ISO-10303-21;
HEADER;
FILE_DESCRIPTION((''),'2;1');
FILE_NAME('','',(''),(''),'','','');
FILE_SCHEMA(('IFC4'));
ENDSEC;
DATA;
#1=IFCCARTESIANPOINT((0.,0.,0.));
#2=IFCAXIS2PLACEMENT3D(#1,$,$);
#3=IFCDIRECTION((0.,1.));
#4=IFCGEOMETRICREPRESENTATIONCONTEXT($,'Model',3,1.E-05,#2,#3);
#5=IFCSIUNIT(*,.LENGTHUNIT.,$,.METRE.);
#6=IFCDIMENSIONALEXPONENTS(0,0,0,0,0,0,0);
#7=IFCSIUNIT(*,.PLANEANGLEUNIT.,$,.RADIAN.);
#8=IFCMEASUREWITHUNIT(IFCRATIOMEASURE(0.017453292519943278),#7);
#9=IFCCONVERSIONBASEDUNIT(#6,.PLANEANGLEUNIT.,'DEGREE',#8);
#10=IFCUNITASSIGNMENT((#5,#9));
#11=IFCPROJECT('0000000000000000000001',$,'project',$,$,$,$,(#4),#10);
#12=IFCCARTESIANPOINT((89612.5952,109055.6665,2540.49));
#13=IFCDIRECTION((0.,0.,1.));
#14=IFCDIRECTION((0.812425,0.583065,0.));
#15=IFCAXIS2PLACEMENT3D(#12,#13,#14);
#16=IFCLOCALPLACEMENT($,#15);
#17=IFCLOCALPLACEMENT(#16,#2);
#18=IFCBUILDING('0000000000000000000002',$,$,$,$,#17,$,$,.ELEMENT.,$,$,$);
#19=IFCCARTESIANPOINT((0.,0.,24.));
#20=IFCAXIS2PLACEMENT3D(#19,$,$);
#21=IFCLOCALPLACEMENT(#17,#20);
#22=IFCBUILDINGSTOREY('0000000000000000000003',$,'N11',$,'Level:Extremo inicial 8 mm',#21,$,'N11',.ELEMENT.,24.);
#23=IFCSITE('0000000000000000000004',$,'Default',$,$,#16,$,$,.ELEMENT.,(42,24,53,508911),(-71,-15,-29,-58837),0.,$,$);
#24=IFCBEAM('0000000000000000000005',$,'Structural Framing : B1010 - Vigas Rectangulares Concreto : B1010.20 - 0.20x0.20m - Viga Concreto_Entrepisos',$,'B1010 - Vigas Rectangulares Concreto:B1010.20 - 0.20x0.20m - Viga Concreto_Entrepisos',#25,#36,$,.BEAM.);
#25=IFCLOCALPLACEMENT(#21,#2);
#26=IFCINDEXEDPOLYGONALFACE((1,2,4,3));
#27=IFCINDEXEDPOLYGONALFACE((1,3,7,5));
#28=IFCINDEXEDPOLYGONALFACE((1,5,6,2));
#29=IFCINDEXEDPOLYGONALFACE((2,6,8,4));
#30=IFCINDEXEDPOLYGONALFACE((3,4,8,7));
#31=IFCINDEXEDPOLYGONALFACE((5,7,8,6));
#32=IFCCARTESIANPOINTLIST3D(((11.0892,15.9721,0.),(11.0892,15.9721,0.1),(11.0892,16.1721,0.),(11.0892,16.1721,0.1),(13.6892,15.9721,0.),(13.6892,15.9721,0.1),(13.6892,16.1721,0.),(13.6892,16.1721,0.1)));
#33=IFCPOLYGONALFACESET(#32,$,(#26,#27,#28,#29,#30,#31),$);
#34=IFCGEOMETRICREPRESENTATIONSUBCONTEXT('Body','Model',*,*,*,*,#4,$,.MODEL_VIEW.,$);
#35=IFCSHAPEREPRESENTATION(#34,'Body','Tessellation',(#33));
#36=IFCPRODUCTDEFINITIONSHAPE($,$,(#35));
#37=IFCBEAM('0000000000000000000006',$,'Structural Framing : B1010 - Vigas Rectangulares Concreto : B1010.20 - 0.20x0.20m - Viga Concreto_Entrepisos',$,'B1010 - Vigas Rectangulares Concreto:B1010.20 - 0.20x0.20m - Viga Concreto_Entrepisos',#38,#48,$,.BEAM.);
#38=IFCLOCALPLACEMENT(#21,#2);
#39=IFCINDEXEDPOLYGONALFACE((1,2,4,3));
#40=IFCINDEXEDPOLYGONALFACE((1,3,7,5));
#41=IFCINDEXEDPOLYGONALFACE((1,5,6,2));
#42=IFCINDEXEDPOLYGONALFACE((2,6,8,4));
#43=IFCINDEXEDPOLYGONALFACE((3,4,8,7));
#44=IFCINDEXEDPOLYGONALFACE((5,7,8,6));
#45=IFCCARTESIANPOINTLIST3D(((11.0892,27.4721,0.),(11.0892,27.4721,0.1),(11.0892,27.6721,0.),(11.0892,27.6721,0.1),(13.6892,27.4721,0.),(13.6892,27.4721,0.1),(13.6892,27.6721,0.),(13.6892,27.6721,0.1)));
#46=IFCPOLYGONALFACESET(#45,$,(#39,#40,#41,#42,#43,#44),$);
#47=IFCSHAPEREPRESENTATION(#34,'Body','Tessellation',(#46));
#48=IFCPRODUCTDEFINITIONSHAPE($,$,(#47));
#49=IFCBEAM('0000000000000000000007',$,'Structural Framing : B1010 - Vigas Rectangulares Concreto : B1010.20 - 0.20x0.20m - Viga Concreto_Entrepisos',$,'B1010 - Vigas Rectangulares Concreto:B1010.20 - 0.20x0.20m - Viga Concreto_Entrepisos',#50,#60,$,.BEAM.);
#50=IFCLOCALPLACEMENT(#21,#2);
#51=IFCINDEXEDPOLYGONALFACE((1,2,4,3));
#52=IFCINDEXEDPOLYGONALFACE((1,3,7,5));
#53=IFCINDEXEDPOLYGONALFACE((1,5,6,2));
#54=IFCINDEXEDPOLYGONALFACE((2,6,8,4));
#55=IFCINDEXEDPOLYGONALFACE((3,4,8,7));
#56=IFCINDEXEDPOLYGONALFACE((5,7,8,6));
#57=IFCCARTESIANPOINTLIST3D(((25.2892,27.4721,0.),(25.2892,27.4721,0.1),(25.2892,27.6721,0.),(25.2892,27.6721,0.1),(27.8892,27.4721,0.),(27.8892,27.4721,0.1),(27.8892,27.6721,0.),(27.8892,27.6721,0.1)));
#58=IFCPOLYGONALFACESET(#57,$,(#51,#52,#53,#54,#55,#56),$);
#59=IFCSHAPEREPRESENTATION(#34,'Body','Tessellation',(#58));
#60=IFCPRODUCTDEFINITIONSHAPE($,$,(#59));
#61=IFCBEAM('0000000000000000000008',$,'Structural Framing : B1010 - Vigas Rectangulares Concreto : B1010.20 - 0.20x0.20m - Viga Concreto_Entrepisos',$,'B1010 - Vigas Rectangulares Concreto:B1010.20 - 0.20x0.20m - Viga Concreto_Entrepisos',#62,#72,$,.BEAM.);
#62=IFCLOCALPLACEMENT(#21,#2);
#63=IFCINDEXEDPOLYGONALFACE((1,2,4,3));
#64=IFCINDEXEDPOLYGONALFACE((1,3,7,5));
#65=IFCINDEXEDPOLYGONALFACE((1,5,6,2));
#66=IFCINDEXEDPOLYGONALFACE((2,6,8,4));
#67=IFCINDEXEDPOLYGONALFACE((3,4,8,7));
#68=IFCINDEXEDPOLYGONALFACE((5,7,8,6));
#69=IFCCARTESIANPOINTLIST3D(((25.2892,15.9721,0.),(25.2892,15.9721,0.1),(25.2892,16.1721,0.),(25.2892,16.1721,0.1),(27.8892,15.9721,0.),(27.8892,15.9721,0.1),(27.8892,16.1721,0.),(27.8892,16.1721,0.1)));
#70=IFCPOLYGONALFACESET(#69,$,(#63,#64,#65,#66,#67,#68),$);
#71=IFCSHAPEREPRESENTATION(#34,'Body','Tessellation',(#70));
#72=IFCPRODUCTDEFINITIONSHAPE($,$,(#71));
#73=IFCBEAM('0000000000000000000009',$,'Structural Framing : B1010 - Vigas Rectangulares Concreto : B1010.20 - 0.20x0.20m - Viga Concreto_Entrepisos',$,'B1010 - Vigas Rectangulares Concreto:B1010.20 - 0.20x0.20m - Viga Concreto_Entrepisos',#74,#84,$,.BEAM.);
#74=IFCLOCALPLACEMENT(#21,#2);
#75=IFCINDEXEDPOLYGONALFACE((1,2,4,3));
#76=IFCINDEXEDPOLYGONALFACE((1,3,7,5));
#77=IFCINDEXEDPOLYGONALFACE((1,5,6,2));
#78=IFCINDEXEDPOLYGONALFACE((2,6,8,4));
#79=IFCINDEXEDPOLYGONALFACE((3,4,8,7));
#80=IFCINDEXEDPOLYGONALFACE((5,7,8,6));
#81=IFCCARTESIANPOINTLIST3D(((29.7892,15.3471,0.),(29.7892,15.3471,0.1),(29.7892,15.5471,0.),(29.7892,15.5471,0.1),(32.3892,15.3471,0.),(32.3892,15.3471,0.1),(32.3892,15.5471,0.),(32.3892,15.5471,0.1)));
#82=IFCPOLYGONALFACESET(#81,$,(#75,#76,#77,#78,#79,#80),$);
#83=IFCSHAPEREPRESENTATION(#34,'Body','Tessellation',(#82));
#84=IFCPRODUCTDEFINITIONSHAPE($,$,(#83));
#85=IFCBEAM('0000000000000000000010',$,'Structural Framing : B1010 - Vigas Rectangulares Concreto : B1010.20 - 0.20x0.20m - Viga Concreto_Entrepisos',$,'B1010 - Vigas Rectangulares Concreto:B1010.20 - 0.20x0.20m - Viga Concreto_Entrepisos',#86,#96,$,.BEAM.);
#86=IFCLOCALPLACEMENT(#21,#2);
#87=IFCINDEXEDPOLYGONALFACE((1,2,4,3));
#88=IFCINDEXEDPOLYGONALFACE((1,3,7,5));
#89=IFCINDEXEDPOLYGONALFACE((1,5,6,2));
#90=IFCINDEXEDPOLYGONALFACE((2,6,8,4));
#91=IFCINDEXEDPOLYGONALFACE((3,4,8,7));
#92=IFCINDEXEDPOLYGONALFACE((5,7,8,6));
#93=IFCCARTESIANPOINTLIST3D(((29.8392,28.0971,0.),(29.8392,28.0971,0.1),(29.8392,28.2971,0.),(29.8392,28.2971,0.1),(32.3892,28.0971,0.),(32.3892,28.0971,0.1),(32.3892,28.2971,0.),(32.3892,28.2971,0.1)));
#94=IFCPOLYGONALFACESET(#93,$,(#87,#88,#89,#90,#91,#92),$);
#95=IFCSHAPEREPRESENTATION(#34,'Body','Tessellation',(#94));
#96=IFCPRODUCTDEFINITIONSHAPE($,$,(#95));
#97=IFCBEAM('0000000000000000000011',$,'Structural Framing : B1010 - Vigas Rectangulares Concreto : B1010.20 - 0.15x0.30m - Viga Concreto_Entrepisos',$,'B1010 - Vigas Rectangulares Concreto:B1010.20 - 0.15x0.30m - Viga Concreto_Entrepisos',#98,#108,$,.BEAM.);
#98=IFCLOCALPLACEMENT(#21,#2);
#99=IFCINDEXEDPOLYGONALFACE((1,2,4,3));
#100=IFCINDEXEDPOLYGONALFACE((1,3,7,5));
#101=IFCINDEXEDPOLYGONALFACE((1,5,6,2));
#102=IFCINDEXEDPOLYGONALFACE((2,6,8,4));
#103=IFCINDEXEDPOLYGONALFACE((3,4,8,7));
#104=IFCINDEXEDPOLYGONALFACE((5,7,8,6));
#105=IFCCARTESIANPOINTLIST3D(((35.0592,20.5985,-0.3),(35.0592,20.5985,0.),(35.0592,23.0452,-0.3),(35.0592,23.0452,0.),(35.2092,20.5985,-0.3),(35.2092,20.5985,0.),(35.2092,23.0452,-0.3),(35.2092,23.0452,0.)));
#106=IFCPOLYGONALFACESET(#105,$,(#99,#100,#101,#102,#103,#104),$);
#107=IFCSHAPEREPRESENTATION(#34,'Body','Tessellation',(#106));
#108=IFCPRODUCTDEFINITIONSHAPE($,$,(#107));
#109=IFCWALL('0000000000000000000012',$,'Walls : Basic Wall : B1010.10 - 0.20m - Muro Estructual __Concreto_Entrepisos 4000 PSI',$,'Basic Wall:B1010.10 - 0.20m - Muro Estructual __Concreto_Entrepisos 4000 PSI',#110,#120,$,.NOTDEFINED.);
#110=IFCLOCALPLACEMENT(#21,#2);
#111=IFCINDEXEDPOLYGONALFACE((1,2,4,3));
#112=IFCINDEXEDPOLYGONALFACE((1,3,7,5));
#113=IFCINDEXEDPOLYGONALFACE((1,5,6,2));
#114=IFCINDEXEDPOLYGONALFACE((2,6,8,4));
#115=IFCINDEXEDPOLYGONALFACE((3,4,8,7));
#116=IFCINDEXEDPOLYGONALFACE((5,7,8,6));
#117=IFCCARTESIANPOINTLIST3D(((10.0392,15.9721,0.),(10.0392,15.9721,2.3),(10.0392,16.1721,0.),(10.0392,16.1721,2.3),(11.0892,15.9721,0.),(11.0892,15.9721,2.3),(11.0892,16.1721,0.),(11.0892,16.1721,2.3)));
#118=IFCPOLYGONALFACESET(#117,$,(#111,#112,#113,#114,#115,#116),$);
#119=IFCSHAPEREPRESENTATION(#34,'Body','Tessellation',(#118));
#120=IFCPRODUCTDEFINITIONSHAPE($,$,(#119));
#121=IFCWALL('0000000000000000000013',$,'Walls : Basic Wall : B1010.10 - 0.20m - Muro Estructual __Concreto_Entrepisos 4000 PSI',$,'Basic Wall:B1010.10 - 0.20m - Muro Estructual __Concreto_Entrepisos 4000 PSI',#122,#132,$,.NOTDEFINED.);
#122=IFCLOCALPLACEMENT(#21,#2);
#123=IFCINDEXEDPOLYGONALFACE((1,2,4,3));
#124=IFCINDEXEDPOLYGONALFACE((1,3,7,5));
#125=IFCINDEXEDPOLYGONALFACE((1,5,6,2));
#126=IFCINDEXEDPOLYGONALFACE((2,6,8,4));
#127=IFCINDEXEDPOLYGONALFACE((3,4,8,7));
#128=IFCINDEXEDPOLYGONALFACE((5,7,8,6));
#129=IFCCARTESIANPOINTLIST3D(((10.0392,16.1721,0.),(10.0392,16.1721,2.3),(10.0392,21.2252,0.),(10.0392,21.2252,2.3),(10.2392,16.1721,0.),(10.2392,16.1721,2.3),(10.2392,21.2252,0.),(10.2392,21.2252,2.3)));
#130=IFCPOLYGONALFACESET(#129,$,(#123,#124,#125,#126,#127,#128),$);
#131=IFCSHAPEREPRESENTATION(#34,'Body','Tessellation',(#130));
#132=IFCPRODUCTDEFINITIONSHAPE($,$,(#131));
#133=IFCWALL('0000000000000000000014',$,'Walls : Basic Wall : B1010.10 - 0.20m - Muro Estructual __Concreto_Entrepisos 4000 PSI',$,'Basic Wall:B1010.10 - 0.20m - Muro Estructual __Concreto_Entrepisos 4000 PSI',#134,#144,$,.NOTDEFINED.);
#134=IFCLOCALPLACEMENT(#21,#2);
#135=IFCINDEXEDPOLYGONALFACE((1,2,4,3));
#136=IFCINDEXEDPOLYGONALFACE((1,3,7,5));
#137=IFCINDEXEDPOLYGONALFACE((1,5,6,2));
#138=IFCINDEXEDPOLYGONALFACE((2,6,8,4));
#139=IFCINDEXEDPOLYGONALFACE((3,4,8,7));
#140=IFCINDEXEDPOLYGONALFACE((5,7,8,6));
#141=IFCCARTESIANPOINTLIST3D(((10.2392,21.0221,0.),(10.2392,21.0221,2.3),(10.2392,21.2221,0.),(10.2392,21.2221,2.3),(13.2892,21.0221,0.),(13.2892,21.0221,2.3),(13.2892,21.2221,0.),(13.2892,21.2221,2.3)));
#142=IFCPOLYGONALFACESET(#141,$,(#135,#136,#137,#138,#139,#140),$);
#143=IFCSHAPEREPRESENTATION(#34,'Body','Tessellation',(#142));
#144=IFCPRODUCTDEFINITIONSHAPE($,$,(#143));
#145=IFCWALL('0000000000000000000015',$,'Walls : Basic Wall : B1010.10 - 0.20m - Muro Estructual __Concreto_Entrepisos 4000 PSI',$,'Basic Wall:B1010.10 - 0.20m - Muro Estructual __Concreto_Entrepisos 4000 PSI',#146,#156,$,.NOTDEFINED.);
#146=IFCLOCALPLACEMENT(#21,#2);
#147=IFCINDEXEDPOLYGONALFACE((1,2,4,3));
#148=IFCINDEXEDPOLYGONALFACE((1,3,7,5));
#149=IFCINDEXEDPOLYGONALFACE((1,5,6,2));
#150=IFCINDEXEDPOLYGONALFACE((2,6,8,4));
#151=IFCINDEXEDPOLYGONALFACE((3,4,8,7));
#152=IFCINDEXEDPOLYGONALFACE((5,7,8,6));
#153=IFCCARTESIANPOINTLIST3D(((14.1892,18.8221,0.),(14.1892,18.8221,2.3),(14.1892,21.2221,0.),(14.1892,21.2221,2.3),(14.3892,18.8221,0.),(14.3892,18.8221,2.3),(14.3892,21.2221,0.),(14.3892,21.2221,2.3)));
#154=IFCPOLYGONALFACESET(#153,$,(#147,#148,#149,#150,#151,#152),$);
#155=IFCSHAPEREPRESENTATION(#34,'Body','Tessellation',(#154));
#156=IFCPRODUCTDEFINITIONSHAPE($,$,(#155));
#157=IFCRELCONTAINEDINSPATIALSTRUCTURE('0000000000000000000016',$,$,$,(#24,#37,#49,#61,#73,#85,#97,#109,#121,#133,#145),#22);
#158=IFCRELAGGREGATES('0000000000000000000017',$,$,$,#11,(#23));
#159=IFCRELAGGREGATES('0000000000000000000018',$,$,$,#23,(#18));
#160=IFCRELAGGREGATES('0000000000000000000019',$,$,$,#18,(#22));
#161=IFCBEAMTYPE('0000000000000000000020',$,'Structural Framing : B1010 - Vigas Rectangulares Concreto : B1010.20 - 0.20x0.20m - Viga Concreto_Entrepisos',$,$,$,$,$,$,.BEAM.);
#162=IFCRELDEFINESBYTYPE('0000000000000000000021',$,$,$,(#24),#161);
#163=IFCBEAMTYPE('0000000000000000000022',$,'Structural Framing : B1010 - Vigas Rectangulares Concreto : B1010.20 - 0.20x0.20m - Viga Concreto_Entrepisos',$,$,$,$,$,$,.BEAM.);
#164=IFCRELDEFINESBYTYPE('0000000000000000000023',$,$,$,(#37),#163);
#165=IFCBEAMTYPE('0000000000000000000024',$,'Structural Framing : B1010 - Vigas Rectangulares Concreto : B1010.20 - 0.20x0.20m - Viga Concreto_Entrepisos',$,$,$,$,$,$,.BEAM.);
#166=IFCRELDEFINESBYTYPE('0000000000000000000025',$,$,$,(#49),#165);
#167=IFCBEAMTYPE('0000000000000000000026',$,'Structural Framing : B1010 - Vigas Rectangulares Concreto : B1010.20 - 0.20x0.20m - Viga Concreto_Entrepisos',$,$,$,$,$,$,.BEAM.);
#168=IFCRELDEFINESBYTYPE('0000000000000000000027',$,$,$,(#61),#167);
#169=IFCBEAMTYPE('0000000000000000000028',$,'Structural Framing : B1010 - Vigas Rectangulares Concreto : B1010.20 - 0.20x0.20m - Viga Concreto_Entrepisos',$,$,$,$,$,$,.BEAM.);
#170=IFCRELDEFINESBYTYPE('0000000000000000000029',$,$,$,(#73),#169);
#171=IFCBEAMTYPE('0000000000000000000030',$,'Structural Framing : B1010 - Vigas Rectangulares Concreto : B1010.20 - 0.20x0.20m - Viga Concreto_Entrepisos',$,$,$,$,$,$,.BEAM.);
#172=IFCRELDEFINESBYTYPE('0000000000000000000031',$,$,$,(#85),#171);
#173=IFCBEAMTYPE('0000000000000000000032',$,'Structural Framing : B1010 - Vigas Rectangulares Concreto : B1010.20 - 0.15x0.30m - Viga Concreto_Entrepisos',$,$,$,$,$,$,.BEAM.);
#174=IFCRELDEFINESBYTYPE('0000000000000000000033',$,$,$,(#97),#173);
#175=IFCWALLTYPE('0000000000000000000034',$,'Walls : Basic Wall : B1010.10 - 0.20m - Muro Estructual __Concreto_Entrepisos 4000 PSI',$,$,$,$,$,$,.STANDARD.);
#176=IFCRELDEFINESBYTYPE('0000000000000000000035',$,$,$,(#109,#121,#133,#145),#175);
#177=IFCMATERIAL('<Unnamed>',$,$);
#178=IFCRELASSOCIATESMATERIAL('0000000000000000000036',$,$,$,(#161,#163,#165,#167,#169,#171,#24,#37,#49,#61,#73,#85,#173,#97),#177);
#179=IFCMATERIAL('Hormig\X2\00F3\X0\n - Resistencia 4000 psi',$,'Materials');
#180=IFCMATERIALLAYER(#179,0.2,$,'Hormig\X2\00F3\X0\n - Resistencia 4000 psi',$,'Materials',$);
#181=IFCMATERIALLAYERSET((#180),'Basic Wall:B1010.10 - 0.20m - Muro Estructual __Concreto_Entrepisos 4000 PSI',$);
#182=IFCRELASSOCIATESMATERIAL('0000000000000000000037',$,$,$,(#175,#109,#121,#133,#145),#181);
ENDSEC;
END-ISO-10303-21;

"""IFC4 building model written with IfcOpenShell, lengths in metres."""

from ifc_helpers import new_model, entity, si_unit, converted_unit, direction, frame, frame_2d, origin, place, context, subcontext, project, spatial, polyline, segment, composite_curve, rectangle, outline, extrude, source, transform, mapped, material, layer, layer_set, layer_usage, material_profile, profile_set, profile_usage, type_object, type_shapes, element, save


model = new_model("IFC4")

# Units and contexts
model_context = context("Model", 3, precision=1e-05, world=origin(), true_north=direction((0.0, 1.0)))
body_context = subcontext(model_context, "Body", "Model", "MODEL_VIEW")
ifc_project = project(units=[si_unit("LENGTHUNIT", "METRE"), converted_unit("PLANEANGLEUNIT", "DEGREE", entity("IfcRatioMeasure", 0.017453292519943278), si_unit("PLANEANGLEUNIT", "RADIAN"), dimensions=[0, 0, 0, 0, 0, 0, 0])], contexts=[model_context])

# Site, building, storey
site_placement = place(None, frame((89612.5952, 109055.6665, 2540.49), z_axis=(0.0, 0.0, 1.0), x_axis=(0.812425, 0.583065, 0.0)))
site = spatial("IfcSite", under=ifc_project, at=site_placement, Name="Default", CompositionType="ELEMENT", RefLatitude=(42, 24, 53, 508911), RefLongitude=(-71, -15, -29, -58837), RefElevation=0.0)
building_placement = place(site_placement, origin())
building = spatial("IfcBuilding", under=site, at=building_placement, CompositionType="ELEMENT")
storey_placement = place(building_placement, frame((0.0, 0.0, 24.0)))
storey = spatial("IfcBuildingStorey", under=building, at=storey_placement, Name="N11", ObjectType="Level:Extremo inicial 8 mm", LongName="N11", CompositionType="ELEMENT", Elevation=24.0)

# Beams
ifc_material_1 = material(Name="<Unnamed>")
ifc_material_profile_1 = material_profile(ifc_material_1, outline(composite_curve([segment(polyline([(-0.1, 0.0, 0.0), (-0.1, 0.1, 0.0)]), True, "CONTINUOUS"), segment(polyline([(-0.1, 0.1, 0.0), (0.1, 0.1, 0.0)]), True, "CONTINUOUS"), segment(polyline([(0.1, 0.1, 0.0), (0.1, 0.0, 0.0)]), True, "CONTINUOUS"), segment(polyline([(0.1, 0.0, 0.0), (-0.1, 0.0, 0.0)]), True, "CONTINUOUS")], self_intersect=False), kind="CURVE"), Name="B1010.20 - 0.20x0.20m - Viga Concreto_Entrepisos")
ifc_material_profile_2 = material_profile(ifc_material_1, outline(composite_curve([segment(polyline([(-1.3, -0.1, 0.1), (-1.3, 0.1, 0.1)]), True, "CONTINUOUS"), segment(polyline([(-1.3, 0.1, 0.1), (-1.3, 0.1, -0.1)]), True, "CONTINUOUS"), segment(polyline([(-1.3, 0.1, -0.1), (-1.3, -0.1, -0.1)]), True, "CONTINUOUS"), segment(polyline([(-1.3, -0.1, -0.1), (-1.3, -0.1, 0.1)]), True, "CONTINUOUS")], self_intersect=False), kind="CURVE"), Name="B1010.20 - 0.20x0.20m - Viga Concreto_Entrepisos")
ifc_profile_set_1 = profile_set([ifc_material_profile_1, ifc_material_profile_2], Name="B1010.20 - 0.20x0.20m - Viga Concreto_Entrepisos")
ifc_profile_usage_1 = profile_usage(ifc_profile_set_1, cardinal=8)
beam_type_1 = type_object("IfcBeamType", Name="Structural Framing : B1010 - Vigas Rectangulares Concreto : B1010.20 - 0.20x0.20m - Viga Concreto_Entrepisos", PredefinedType="BEAM", material=ifc_profile_set_1)
shared_shape_1 = source(origin(), body_context, "Body", "SweptSolid", [
    extrude(rectangle(XDim=0.1, YDim=0.2, at=frame_2d((0.0, 0.0), x_axis=(1.0, 0.0))), frame((13.6892, 16.0721, 24.05), z_axis=(-1.0, 0.0, 0.0), x_axis=(0.0, 0.0, -1.0)), (0.0, 0.0, 1.0), 2.6),
])
type_shapes(beam_type_1, [shared_shape_1])
beam_1_placement = place(storey_placement, frame((0.0, 0.0, -24.0)))
element("IfcBeam", 1, at=beam_1_placement, inside=storey, type_object=beam_type_1, material=ifc_profile_usage_1, Name="Structural Framing : B1010 - Vigas Rectangulares Concreto : B1010.20 - 0.20x0.20m - Viga Concreto_Entrepisos", ObjectType="B1010 - Vigas Rectangulares Concreto:B1010.20 - 0.20x0.20m - Viga Concreto_Entrepisos", PredefinedType="BEAM", context=body_context, shape_type="MappedRepresentation", body=[
    mapped(shared_shape_1, transform((0.0, 0.0, 0.0), scale=1.0)),
])
ifc_profile_usage_2 = profile_usage(ifc_profile_set_1, cardinal=8)
beam_type_2 = type_object("IfcBeamType", Name="Structural Framing : B1010 - Vigas Rectangulares Concreto : B1010.20 - 0.20x0.20m - Viga Concreto_Entrepisos", PredefinedType="BEAM", material=ifc_profile_set_1)
shared_shape_2 = source(origin(), body_context, "Body", "SweptSolid", [
    extrude(rectangle(XDim=0.1, YDim=0.2, at=frame_2d((0.0, 0.0), x_axis=(1.0, 0.0))), frame((13.6892, 27.5721, 24.05), z_axis=(-1.0, 0.0, 0.0), x_axis=(0.0, 0.0, -1.0)), (0.0, 0.0, 1.0), 2.6),
])
type_shapes(beam_type_2, [shared_shape_2])
beam_2_placement = place(storey_placement, frame((0.0, 0.0, -24.0)))
element("IfcBeam", 2, at=beam_2_placement, inside=storey, type_object=beam_type_2, material=ifc_profile_usage_2, Name="Structural Framing : B1010 - Vigas Rectangulares Concreto : B1010.20 - 0.20x0.20m - Viga Concreto_Entrepisos", ObjectType="B1010 - Vigas Rectangulares Concreto:B1010.20 - 0.20x0.20m - Viga Concreto_Entrepisos", PredefinedType="BEAM", context=body_context, shape_type="MappedRepresentation", body=[
    mapped(shared_shape_2, transform((0.0, 0.0, 0.0), scale=1.0)),
])
ifc_profile_usage_3 = profile_usage(ifc_profile_set_1, cardinal=8)
beam_type_3 = type_object("IfcBeamType", Name="Structural Framing : B1010 - Vigas Rectangulares Concreto : B1010.20 - 0.20x0.20m - Viga Concreto_Entrepisos", PredefinedType="BEAM", material=ifc_profile_set_1)
shared_shape_3 = source(origin(), body_context, "Body", "SweptSolid", [
    extrude(rectangle(XDim=0.1, YDim=0.2, at=frame_2d((0.0, 0.0), x_axis=(1.0, 0.0))), frame((25.2892, 27.5721, 24.05), z_axis=(1.0, 0.0, 0.0), x_axis=(0.0, 0.0, -1.0)), (0.0, 0.0, 1.0), 2.6),
])
type_shapes(beam_type_3, [shared_shape_3])
beam_3_placement = place(storey_placement, frame((0.0, 0.0, -24.0)))
element("IfcBeam", 3, at=beam_3_placement, inside=storey, type_object=beam_type_3, material=ifc_profile_usage_3, Name="Structural Framing : B1010 - Vigas Rectangulares Concreto : B1010.20 - 0.20x0.20m - Viga Concreto_Entrepisos", ObjectType="B1010 - Vigas Rectangulares Concreto:B1010.20 - 0.20x0.20m - Viga Concreto_Entrepisos", PredefinedType="BEAM", context=body_context, shape_type="MappedRepresentation", body=[
    mapped(shared_shape_3, transform((0.0, 0.0, 0.0), scale=1.0)),
])
ifc_profile_usage_4 = profile_usage(ifc_profile_set_1, cardinal=8)
beam_type_4 = type_object("IfcBeamType", Name="Structural Framing : B1010 - Vigas Rectangulares Concreto : B1010.20 - 0.20x0.20m - Viga Concreto_Entrepisos", PredefinedType="BEAM", material=ifc_profile_set_1)
shared_shape_4 = source(origin(), body_context, "Body", "SweptSolid", [
    extrude(rectangle(XDim=0.1, YDim=0.2, at=frame_2d((0.0, 0.0), x_axis=(1.0, 0.0))), frame((25.2892, 16.0721, 24.05), z_axis=(1.0, 0.0, 0.0), x_axis=(0.0, 0.0, -1.0)), (0.0, 0.0, 1.0), 2.6),
])
type_shapes(beam_type_4, [shared_shape_4])
beam_4_placement = place(storey_placement, frame((0.0, 0.0, -24.0)))
element("IfcBeam", 4, at=beam_4_placement, inside=storey, type_object=beam_type_4, material=ifc_profile_usage_4, Name="Structural Framing : B1010 - Vigas Rectangulares Concreto : B1010.20 - 0.20x0.20m - Viga Concreto_Entrepisos", ObjectType="B1010 - Vigas Rectangulares Concreto:B1010.20 - 0.20x0.20m - Viga Concreto_Entrepisos", PredefinedType="BEAM", context=body_context, shape_type="MappedRepresentation", body=[
    mapped(shared_shape_4, transform((0.0, 0.0, 0.0), scale=1.0)),
])
ifc_profile_usage_5 = profile_usage(ifc_profile_set_1, cardinal=8)
beam_type_5 = type_object("IfcBeamType", Name="Structural Framing : B1010 - Vigas Rectangulares Concreto : B1010.20 - 0.20x0.20m - Viga Concreto_Entrepisos", PredefinedType="BEAM", material=ifc_profile_set_1)
shared_shape_5 = source(origin(), body_context, "Body", "SweptSolid", [
    extrude(rectangle(XDim=0.1, YDim=0.2, at=frame_2d((0.0, 0.0), x_axis=(1.0, 0.0))), frame((32.3892, 15.4471, 24.05), z_axis=(-1.0, 0.0, 0.0), x_axis=(0.0, 0.0, -1.0)), (0.0, 0.0, 1.0), 2.6),
])
type_shapes(beam_type_5, [shared_shape_5])
beam_5_placement = place(storey_placement, frame((0.0, 0.0, -24.0)))
element("IfcBeam", 5, at=beam_5_placement, inside=storey, type_object=beam_type_5, material=ifc_profile_usage_5, Name="Structural Framing : B1010 - Vigas Rectangulares Concreto : B1010.20 - 0.20x0.20m - Viga Concreto_Entrepisos", ObjectType="B1010 - Vigas Rectangulares Concreto:B1010.20 - 0.20x0.20m - Viga Concreto_Entrepisos", PredefinedType="BEAM", context=body_context, shape_type="MappedRepresentation", body=[
    mapped(shared_shape_5, transform((0.0, 0.0, 0.0), scale=1.0)),
])
ifc_profile_usage_6 = profile_usage(ifc_profile_set_1, cardinal=8)
beam_type_6 = type_object("IfcBeamType", Name="Structural Framing : B1010 - Vigas Rectangulares Concreto : B1010.20 - 0.20x0.20m - Viga Concreto_Entrepisos", PredefinedType="BEAM", material=ifc_profile_set_1)
shared_shape_6 = source(origin(), body_context, "Body", "SweptSolid", [
    extrude(rectangle(XDim=0.1, YDim=0.2, at=frame_2d((0.0, 0.0), x_axis=(1.0, 0.0))), frame((29.8392, 28.1971, 24.05), z_axis=(1.0, 0.0, 0.0), x_axis=(0.0, 0.0, -1.0)), (0.0, 0.0, 1.0), 2.55),
])
type_shapes(beam_type_6, [shared_shape_6])
beam_6_placement = place(storey_placement, frame((0.0, 0.0, -24.0)))
element("IfcBeam", 6, at=beam_6_placement, inside=storey, type_object=beam_type_6, material=ifc_profile_usage_6, Name="Structural Framing : B1010 - Vigas Rectangulares Concreto : B1010.20 - 0.20x0.20m - Viga Concreto_Entrepisos", ObjectType="B1010 - Vigas Rectangulares Concreto:B1010.20 - 0.20x0.20m - Viga Concreto_Entrepisos", PredefinedType="BEAM", context=body_context, shape_type="MappedRepresentation", body=[
    mapped(shared_shape_6, transform((0.0, 0.0, 0.0), scale=1.0)),
])
ifc_material_profile_3 = material_profile(ifc_material_1, outline(composite_curve([segment(polyline([(-0.075, -0.15, 0.0), (-0.075, 0.15, 0.0)]), True, "CONTINUOUS"), segment(polyline([(-0.075, 0.15, 0.0), (0.075, 0.15, 0.0)]), True, "CONTINUOUS"), segment(polyline([(0.075, 0.15, 0.0), (0.075, -0.15, 0.0)]), True, "CONTINUOUS"), segment(polyline([(0.075, -0.15, 0.0), (-0.075, -0.15, 0.0)]), True, "CONTINUOUS")], self_intersect=False), kind="CURVE"), Name="B1010.20 - 0.15x0.30m - Viga Concreto_Entrepisos")
ifc_material_profile_4 = material_profile(ifc_material_1, outline(composite_curve([segment(polyline([(1.2233, 0.075, 0.15), (1.2233, 0.075, -0.15)]), True, "CONTINUOUS"), segment(polyline([(1.2233, 0.075, -0.15), (-1.2233, 0.075, -0.15)]), True, "CONTINUOUS"), segment(polyline([(-1.2233, 0.075, -0.15), (-1.2233, 0.075, 0.15)]), True, "CONTINUOUS"), segment(polyline([(-1.2233, 0.075, 0.15), (1.2233, 0.075, 0.15)]), True, "CONTINUOUS")], self_intersect=False), kind="CURVE"), Name="B1010.20 - 0.15x0.30m - Viga Concreto_Entrepisos")
ifc_profile_set_2 = profile_set([ifc_material_profile_3, ifc_material_profile_4], Name="B1010.20 - 0.15x0.30m - Viga Concreto_Entrepisos")
ifc_profile_usage_7 = profile_usage(ifc_profile_set_2, cardinal=8)
beam_type_7 = type_object("IfcBeamType", Name="Structural Framing : B1010 - Vigas Rectangulares Concreto : B1010.20 - 0.15x0.30m - Viga Concreto_Entrepisos", PredefinedType="BEAM", material=ifc_profile_set_2)
shared_shape_7 = source(origin(), body_context, "Body", "SweptSolid", [
    extrude(rectangle(XDim=0.3, YDim=0.15, at=frame_2d((0.0, 0.0), x_axis=(0.0, 1.0))), frame((35.1342, 20.5985, 23.85), z_axis=(0.0, 1.0, 0.0), x_axis=(-1.0, 0.0, 0.0)), (0.0, 0.0, 1.0), 2.4467),
])
type_shapes(beam_type_7, [shared_shape_7])
beam_7_placement = place(storey_placement, frame((0.0, 0.0, -24.0)))
element("IfcBeam", 7, at=beam_7_placement, inside=storey, type_object=beam_type_7, material=ifc_profile_usage_7, Name="Structural Framing : B1010 - Vigas Rectangulares Concreto : B1010.20 - 0.15x0.30m - Viga Concreto_Entrepisos", ObjectType="B1010 - Vigas Rectangulares Concreto:B1010.20 - 0.15x0.30m - Viga Concreto_Entrepisos", PredefinedType="BEAM", context=body_context, shape_type="MappedRepresentation", body=[
    mapped(shared_shape_7, transform((0.0, 0.0, 0.0), scale=1.0)),
])

# Walls
ifc_material_2 = material(Name="Hormigón - Resistencia 4000 psi", Category="Materials")
ifc_layer_1 = layer(ifc_material_2, 0.2, Name="Hormigón - Resistencia 4000 psi", Category="Materials")
ifc_layer_set_1 = layer_set([ifc_layer_1], Name="Basic Wall:B1010.10 - 0.20m - Muro Estructual __Concreto_Entrepisos 4000 PSI")
ifc_layer_usage_1 = layer_usage(ifc_layer_set_1, "AXIS2", "NEGATIVE", 0.1)
wall_type_1 = type_object("IfcWallType", Name="Walls : Basic Wall : B1010.10 - 0.20m - Muro Estructual __Concreto_Entrepisos 4000 PSI", PredefinedType="STANDARD", material=ifc_layer_set_1)
wall_1_placement = place(storey_placement, frame((11.0892, 16.0721, 0.0), z_axis=(0.0, 0.0, 1.0), x_axis=(-1.0, 0.0, 0.0)))
element("IfcWall", 8, at=wall_1_placement, inside=storey, type_object=wall_type_1, material=ifc_layer_usage_1, Name="Walls : Basic Wall : B1010.10 - 0.20m - Muro Estructual __Concreto_Entrepisos 4000 PSI", ObjectType="Basic Wall:B1010.10 - 0.20m - Muro Estructual __Concreto_Entrepisos 4000 PSI", PredefinedType="NOTDEFINED", context=body_context, shape_type="SweptSolid", body=[
    extrude(rectangle(XDim=1.05, YDim=0.2, at=frame_2d((0.525, 0.0), x_axis=(-1.0, 0.0))), origin(), (0.0, 0.0, 1.0), 2.3),
])
ifc_layer_usage_2 = layer_usage(ifc_layer_set_1, "AXIS2", "NEGATIVE", 0.1)
wall_2_placement = place(storey_placement, frame((10.1392, 16.1721, 0.0), z_axis=(0.0, 0.0, 1.0), x_axis=(0.0, 1.0, 0.0)))
element("IfcWall", 9, at=wall_2_placement, inside=storey, type_object=wall_type_1, material=ifc_layer_usage_2, Name="Walls : Basic Wall : B1010.10 - 0.20m - Muro Estructual __Concreto_Entrepisos 4000 PSI", ObjectType="Basic Wall:B1010.10 - 0.20m - Muro Estructual __Concreto_Entrepisos 4000 PSI", PredefinedType="NOTDEFINED", context=body_context, shape_type="SweptSolid", body=[
    extrude(rectangle(XDim=5.0531, YDim=0.2, at=frame_2d((2.5265, 0.0), x_axis=(-1.0, 0.0))), origin(), (0.0, 0.0, 1.0), 2.3),
])
ifc_layer_usage_3 = layer_usage(ifc_layer_set_1, "AXIS2", "NEGATIVE", 0.1)
wall_3_placement = place(storey_placement, frame((10.2392, 21.1221, 0.0)))
element("IfcWall", 10, at=wall_3_placement, inside=storey, type_object=wall_type_1, material=ifc_layer_usage_3, Name="Walls : Basic Wall : B1010.10 - 0.20m - Muro Estructual __Concreto_Entrepisos 4000 PSI", ObjectType="Basic Wall:B1010.10 - 0.20m - Muro Estructual __Concreto_Entrepisos 4000 PSI", PredefinedType="NOTDEFINED", context=body_context, shape_type="SweptSolid", body=[
    extrude(rectangle(XDim=3.05, YDim=0.2, at=frame_2d((1.525, 0.0), x_axis=(-1.0, 0.0))), origin(), (0.0, 0.0, 1.0), 2.3),
])
ifc_layer_usage_4 = layer_usage(ifc_layer_set_1, "AXIS2", "NEGATIVE", 0.1)
wall_4_placement = place(storey_placement, frame((14.2892, 18.8221, 0.0), z_axis=(0.0, 0.0, 1.0), x_axis=(0.0, 1.0, 0.0)))
element("IfcWall", 11, at=wall_4_placement, inside=storey, type_object=wall_type_1, material=ifc_layer_usage_4, Name="Walls : Basic Wall : B1010.10 - 0.20m - Muro Estructual __Concreto_Entrepisos 4000 PSI", ObjectType="Basic Wall:B1010.10 - 0.20m - Muro Estructual __Concreto_Entrepisos 4000 PSI", PredefinedType="NOTDEFINED", context=body_context, shape_type="SweptSolid", body=[
    extrude(rectangle(XDim=2.4, YDim=0.2, at=frame_2d((1.2, 0.0), x_axis=(-1.0, 0.0))), origin(), (0.0, 0.0, 1.0), 2.3),
])

save(model, "model.ifc")
